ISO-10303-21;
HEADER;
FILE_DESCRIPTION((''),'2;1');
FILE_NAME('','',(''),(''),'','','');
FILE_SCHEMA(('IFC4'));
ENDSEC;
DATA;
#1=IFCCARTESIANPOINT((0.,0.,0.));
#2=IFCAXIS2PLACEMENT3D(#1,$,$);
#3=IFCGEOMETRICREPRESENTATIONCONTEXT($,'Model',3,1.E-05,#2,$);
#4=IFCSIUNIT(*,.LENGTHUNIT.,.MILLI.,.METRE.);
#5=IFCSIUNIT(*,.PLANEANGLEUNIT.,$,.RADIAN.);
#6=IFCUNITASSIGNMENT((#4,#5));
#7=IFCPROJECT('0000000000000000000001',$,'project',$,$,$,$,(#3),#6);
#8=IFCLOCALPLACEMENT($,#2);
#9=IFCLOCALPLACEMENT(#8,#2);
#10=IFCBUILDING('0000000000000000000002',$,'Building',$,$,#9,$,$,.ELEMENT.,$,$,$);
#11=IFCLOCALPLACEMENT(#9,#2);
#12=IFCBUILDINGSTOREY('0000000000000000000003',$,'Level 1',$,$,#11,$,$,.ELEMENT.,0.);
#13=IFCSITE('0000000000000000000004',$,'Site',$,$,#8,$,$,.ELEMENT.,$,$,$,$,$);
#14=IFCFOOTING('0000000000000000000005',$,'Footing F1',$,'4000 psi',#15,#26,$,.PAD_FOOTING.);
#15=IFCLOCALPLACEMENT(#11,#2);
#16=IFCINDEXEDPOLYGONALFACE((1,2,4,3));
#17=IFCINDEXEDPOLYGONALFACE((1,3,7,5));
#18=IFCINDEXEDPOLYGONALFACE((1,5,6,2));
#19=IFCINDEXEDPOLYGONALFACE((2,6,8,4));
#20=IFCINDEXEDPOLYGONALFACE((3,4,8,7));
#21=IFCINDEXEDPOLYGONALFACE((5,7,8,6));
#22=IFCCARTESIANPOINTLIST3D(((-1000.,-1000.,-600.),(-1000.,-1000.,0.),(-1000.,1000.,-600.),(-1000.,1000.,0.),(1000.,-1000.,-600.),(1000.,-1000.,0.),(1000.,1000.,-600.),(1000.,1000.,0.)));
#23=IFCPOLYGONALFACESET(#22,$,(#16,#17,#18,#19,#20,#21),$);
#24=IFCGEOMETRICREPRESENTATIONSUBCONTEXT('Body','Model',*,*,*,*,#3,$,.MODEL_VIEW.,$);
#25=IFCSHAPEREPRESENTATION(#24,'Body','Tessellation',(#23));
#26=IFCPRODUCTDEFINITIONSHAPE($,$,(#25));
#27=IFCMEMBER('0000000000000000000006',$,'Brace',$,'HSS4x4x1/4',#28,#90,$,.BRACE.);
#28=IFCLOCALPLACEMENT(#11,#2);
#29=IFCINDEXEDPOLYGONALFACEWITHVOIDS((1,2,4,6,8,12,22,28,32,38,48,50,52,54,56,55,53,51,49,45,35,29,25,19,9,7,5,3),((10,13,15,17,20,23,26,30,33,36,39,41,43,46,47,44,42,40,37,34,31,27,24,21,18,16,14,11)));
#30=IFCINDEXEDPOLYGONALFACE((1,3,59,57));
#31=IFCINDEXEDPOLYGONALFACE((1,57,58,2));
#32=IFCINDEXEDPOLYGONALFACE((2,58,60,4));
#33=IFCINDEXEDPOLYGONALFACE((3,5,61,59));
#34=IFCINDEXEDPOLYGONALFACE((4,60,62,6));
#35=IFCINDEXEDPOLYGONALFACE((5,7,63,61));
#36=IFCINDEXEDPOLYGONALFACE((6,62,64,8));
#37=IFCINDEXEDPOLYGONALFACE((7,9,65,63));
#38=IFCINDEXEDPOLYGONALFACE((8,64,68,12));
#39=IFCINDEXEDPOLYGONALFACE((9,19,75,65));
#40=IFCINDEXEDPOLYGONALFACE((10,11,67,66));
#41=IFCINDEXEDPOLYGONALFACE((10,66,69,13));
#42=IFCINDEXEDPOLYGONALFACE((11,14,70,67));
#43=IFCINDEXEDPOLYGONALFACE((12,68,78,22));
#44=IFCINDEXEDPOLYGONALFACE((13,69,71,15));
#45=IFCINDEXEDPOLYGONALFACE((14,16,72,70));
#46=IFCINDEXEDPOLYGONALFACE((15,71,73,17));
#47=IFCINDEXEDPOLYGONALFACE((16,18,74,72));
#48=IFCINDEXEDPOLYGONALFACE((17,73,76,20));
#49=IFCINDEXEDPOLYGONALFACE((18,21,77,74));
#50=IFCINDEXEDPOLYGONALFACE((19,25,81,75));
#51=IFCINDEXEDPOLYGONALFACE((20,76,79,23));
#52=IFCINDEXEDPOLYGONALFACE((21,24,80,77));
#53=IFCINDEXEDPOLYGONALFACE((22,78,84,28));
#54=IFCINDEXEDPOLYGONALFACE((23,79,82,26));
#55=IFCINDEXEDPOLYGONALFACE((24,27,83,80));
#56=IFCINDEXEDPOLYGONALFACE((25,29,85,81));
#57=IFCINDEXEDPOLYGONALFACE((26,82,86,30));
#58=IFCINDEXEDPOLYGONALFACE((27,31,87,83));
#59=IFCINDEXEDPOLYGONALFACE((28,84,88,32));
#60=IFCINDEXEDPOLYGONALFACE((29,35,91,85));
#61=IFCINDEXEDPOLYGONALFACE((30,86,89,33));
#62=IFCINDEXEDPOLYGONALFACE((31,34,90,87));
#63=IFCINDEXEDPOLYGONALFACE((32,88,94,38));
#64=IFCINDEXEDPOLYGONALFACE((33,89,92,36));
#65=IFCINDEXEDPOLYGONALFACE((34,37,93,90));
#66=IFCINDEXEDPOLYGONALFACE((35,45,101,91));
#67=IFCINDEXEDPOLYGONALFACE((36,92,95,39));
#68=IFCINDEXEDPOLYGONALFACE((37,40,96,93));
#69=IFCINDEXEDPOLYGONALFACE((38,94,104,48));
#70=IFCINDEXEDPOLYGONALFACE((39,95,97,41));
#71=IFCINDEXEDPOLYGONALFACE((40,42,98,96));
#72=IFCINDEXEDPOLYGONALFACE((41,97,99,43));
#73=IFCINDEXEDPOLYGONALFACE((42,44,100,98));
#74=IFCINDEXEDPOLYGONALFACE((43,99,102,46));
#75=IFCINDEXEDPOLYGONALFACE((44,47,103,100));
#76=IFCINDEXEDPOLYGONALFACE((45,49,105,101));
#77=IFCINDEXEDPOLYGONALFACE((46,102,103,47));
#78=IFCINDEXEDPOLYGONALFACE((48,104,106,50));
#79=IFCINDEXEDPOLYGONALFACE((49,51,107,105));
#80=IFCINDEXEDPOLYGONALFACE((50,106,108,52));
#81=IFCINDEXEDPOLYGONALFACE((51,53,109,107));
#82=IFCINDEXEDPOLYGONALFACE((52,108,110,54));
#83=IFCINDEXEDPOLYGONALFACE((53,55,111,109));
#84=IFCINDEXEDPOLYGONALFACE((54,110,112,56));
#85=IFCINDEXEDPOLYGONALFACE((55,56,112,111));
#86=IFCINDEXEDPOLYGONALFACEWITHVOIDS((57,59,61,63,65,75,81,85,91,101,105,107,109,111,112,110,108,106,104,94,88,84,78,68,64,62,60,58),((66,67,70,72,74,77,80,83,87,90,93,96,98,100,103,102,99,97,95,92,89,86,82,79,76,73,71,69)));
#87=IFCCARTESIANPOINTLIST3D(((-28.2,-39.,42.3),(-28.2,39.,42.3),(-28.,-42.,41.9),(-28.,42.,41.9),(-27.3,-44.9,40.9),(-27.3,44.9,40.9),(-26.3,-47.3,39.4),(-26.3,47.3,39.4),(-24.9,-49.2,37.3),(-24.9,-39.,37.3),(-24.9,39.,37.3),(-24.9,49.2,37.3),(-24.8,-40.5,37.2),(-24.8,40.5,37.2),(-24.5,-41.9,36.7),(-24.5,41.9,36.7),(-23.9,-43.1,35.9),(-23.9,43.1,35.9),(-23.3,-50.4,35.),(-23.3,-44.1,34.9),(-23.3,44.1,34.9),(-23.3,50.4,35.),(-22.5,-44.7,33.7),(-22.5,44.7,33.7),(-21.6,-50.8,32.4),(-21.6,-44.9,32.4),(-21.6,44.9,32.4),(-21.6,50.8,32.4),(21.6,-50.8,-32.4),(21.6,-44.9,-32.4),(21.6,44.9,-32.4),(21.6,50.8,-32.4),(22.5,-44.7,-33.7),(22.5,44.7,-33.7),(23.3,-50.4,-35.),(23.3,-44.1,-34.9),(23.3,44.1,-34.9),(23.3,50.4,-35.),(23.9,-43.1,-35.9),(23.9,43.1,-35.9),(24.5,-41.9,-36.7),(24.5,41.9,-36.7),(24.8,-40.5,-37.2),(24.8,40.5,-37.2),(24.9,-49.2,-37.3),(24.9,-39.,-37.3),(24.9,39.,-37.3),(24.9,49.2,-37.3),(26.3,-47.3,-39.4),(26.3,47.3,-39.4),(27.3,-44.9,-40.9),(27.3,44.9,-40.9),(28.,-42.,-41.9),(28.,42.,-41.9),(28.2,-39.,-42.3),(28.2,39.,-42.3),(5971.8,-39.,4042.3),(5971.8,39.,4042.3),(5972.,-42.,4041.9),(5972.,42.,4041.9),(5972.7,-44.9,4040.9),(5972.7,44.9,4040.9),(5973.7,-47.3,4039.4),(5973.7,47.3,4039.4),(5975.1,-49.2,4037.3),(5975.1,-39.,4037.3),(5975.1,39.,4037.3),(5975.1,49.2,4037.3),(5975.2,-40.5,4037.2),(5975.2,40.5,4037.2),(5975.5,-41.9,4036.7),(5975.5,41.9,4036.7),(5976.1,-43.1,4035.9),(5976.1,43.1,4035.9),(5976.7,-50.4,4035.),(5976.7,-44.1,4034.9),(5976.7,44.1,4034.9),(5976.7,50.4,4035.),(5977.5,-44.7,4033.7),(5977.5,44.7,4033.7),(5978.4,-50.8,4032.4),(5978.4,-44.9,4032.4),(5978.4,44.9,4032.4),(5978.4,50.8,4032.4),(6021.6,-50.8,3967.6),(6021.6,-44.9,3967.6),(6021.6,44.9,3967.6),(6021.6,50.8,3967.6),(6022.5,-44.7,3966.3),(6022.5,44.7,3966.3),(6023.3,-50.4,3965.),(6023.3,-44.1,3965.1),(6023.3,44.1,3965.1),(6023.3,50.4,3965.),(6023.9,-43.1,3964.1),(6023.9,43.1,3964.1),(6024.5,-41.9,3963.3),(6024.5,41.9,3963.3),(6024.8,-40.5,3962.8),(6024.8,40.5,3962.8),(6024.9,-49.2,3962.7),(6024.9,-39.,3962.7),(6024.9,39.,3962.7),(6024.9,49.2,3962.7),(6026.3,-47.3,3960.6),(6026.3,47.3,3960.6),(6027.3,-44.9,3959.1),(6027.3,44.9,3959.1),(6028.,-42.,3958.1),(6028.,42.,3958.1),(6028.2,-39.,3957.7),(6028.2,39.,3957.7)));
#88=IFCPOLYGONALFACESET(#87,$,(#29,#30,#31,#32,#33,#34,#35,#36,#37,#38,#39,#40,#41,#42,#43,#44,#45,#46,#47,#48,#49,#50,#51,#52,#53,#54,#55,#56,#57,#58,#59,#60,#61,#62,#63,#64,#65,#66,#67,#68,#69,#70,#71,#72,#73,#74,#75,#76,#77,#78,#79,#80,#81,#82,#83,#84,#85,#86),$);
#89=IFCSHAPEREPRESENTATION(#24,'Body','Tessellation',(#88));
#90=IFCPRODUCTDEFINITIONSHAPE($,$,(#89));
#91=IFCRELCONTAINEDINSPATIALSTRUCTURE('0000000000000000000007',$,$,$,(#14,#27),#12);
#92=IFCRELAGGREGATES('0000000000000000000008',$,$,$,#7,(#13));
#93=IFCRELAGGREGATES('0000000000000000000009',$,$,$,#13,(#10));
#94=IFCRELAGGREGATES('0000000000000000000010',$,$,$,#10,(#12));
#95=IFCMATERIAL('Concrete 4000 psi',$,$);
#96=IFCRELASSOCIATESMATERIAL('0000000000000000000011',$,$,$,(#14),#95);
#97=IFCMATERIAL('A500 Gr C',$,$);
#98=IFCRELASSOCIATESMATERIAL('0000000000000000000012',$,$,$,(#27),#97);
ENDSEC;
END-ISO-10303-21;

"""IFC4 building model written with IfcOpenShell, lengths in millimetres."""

from ifc_helpers import new_model, si_unit, frame, origin, origin_2d, place, context, subcontext, project, spatial, rectangle, hollow_rectangle, extrude, material, element, save


model = new_model("IFC4")

# Units and contexts
model_context = context("Model", 3, precision=1e-05, world=origin())
body_context = subcontext(model_context, "Body", "Model", "MODEL_VIEW")
ifc_project = project(units=[si_unit("LENGTHUNIT", "METRE", prefix="MILLI"), si_unit("PLANEANGLEUNIT", "RADIAN")], contexts=[model_context])

# Site, building, storey
site_placement = place(None, origin())
site = spatial("IfcSite", under=ifc_project, at=site_placement, Name="Site", CompositionType="ELEMENT")
building_placement = place(site_placement, origin())
building = spatial("IfcBuilding", under=site, at=building_placement, Name="Building", CompositionType="ELEMENT")
storey_placement = place(building_placement, origin())
storey = spatial("IfcBuildingStorey", under=building, at=storey_placement, Name="Level 1", CompositionType="ELEMENT", Elevation=0.0)

# Footing
ifc_material_1 = material(Name="Concrete 4000 psi")
footing_placement = place(storey_placement, frame((0.0, 0.0, -600.0), z_axis=(0.0, 0.0, 1.0), x_axis=(1.0, 0.0, 0.0)))
element("IfcFooting", 1, at=footing_placement, inside=storey, material=ifc_material_1, Name="Footing F1", ObjectType="4000 psi", PredefinedType="PAD_FOOTING", context=body_context, shape_type="SweptSolid", body=[
    extrude(rectangle(XDim=2000.0, YDim=2000.0, at=origin_2d()), origin(), (0.0, 0.0, 1.0), 600.0),
])

# Member
ifc_material_2 = material(Name="A500 Gr C")
member_placement = place(storey_placement, frame((0.0, 0.0, 0.0), z_axis=(0.83205, 0.0, 0.5547), x_axis=(0.0, 1.0, 0.0)))
element("IfcMember", 2, at=member_placement, inside=storey, material=ifc_material_2, Name="Brace", ObjectType="HSS4x4x1/4", PredefinedType="BRACE", context=body_context, shape_type="SweptSolid", body=[
    extrude(hollow_rectangle(XDim=101.6, YDim=101.6, WallThickness=5.9, InnerFilletRadius=5.9, OuterFilletRadius=11.8, at=origin_2d()), origin(), (0.0, 0.0, 1.0), 7211.1),
])

save(model, "model.ifc")
